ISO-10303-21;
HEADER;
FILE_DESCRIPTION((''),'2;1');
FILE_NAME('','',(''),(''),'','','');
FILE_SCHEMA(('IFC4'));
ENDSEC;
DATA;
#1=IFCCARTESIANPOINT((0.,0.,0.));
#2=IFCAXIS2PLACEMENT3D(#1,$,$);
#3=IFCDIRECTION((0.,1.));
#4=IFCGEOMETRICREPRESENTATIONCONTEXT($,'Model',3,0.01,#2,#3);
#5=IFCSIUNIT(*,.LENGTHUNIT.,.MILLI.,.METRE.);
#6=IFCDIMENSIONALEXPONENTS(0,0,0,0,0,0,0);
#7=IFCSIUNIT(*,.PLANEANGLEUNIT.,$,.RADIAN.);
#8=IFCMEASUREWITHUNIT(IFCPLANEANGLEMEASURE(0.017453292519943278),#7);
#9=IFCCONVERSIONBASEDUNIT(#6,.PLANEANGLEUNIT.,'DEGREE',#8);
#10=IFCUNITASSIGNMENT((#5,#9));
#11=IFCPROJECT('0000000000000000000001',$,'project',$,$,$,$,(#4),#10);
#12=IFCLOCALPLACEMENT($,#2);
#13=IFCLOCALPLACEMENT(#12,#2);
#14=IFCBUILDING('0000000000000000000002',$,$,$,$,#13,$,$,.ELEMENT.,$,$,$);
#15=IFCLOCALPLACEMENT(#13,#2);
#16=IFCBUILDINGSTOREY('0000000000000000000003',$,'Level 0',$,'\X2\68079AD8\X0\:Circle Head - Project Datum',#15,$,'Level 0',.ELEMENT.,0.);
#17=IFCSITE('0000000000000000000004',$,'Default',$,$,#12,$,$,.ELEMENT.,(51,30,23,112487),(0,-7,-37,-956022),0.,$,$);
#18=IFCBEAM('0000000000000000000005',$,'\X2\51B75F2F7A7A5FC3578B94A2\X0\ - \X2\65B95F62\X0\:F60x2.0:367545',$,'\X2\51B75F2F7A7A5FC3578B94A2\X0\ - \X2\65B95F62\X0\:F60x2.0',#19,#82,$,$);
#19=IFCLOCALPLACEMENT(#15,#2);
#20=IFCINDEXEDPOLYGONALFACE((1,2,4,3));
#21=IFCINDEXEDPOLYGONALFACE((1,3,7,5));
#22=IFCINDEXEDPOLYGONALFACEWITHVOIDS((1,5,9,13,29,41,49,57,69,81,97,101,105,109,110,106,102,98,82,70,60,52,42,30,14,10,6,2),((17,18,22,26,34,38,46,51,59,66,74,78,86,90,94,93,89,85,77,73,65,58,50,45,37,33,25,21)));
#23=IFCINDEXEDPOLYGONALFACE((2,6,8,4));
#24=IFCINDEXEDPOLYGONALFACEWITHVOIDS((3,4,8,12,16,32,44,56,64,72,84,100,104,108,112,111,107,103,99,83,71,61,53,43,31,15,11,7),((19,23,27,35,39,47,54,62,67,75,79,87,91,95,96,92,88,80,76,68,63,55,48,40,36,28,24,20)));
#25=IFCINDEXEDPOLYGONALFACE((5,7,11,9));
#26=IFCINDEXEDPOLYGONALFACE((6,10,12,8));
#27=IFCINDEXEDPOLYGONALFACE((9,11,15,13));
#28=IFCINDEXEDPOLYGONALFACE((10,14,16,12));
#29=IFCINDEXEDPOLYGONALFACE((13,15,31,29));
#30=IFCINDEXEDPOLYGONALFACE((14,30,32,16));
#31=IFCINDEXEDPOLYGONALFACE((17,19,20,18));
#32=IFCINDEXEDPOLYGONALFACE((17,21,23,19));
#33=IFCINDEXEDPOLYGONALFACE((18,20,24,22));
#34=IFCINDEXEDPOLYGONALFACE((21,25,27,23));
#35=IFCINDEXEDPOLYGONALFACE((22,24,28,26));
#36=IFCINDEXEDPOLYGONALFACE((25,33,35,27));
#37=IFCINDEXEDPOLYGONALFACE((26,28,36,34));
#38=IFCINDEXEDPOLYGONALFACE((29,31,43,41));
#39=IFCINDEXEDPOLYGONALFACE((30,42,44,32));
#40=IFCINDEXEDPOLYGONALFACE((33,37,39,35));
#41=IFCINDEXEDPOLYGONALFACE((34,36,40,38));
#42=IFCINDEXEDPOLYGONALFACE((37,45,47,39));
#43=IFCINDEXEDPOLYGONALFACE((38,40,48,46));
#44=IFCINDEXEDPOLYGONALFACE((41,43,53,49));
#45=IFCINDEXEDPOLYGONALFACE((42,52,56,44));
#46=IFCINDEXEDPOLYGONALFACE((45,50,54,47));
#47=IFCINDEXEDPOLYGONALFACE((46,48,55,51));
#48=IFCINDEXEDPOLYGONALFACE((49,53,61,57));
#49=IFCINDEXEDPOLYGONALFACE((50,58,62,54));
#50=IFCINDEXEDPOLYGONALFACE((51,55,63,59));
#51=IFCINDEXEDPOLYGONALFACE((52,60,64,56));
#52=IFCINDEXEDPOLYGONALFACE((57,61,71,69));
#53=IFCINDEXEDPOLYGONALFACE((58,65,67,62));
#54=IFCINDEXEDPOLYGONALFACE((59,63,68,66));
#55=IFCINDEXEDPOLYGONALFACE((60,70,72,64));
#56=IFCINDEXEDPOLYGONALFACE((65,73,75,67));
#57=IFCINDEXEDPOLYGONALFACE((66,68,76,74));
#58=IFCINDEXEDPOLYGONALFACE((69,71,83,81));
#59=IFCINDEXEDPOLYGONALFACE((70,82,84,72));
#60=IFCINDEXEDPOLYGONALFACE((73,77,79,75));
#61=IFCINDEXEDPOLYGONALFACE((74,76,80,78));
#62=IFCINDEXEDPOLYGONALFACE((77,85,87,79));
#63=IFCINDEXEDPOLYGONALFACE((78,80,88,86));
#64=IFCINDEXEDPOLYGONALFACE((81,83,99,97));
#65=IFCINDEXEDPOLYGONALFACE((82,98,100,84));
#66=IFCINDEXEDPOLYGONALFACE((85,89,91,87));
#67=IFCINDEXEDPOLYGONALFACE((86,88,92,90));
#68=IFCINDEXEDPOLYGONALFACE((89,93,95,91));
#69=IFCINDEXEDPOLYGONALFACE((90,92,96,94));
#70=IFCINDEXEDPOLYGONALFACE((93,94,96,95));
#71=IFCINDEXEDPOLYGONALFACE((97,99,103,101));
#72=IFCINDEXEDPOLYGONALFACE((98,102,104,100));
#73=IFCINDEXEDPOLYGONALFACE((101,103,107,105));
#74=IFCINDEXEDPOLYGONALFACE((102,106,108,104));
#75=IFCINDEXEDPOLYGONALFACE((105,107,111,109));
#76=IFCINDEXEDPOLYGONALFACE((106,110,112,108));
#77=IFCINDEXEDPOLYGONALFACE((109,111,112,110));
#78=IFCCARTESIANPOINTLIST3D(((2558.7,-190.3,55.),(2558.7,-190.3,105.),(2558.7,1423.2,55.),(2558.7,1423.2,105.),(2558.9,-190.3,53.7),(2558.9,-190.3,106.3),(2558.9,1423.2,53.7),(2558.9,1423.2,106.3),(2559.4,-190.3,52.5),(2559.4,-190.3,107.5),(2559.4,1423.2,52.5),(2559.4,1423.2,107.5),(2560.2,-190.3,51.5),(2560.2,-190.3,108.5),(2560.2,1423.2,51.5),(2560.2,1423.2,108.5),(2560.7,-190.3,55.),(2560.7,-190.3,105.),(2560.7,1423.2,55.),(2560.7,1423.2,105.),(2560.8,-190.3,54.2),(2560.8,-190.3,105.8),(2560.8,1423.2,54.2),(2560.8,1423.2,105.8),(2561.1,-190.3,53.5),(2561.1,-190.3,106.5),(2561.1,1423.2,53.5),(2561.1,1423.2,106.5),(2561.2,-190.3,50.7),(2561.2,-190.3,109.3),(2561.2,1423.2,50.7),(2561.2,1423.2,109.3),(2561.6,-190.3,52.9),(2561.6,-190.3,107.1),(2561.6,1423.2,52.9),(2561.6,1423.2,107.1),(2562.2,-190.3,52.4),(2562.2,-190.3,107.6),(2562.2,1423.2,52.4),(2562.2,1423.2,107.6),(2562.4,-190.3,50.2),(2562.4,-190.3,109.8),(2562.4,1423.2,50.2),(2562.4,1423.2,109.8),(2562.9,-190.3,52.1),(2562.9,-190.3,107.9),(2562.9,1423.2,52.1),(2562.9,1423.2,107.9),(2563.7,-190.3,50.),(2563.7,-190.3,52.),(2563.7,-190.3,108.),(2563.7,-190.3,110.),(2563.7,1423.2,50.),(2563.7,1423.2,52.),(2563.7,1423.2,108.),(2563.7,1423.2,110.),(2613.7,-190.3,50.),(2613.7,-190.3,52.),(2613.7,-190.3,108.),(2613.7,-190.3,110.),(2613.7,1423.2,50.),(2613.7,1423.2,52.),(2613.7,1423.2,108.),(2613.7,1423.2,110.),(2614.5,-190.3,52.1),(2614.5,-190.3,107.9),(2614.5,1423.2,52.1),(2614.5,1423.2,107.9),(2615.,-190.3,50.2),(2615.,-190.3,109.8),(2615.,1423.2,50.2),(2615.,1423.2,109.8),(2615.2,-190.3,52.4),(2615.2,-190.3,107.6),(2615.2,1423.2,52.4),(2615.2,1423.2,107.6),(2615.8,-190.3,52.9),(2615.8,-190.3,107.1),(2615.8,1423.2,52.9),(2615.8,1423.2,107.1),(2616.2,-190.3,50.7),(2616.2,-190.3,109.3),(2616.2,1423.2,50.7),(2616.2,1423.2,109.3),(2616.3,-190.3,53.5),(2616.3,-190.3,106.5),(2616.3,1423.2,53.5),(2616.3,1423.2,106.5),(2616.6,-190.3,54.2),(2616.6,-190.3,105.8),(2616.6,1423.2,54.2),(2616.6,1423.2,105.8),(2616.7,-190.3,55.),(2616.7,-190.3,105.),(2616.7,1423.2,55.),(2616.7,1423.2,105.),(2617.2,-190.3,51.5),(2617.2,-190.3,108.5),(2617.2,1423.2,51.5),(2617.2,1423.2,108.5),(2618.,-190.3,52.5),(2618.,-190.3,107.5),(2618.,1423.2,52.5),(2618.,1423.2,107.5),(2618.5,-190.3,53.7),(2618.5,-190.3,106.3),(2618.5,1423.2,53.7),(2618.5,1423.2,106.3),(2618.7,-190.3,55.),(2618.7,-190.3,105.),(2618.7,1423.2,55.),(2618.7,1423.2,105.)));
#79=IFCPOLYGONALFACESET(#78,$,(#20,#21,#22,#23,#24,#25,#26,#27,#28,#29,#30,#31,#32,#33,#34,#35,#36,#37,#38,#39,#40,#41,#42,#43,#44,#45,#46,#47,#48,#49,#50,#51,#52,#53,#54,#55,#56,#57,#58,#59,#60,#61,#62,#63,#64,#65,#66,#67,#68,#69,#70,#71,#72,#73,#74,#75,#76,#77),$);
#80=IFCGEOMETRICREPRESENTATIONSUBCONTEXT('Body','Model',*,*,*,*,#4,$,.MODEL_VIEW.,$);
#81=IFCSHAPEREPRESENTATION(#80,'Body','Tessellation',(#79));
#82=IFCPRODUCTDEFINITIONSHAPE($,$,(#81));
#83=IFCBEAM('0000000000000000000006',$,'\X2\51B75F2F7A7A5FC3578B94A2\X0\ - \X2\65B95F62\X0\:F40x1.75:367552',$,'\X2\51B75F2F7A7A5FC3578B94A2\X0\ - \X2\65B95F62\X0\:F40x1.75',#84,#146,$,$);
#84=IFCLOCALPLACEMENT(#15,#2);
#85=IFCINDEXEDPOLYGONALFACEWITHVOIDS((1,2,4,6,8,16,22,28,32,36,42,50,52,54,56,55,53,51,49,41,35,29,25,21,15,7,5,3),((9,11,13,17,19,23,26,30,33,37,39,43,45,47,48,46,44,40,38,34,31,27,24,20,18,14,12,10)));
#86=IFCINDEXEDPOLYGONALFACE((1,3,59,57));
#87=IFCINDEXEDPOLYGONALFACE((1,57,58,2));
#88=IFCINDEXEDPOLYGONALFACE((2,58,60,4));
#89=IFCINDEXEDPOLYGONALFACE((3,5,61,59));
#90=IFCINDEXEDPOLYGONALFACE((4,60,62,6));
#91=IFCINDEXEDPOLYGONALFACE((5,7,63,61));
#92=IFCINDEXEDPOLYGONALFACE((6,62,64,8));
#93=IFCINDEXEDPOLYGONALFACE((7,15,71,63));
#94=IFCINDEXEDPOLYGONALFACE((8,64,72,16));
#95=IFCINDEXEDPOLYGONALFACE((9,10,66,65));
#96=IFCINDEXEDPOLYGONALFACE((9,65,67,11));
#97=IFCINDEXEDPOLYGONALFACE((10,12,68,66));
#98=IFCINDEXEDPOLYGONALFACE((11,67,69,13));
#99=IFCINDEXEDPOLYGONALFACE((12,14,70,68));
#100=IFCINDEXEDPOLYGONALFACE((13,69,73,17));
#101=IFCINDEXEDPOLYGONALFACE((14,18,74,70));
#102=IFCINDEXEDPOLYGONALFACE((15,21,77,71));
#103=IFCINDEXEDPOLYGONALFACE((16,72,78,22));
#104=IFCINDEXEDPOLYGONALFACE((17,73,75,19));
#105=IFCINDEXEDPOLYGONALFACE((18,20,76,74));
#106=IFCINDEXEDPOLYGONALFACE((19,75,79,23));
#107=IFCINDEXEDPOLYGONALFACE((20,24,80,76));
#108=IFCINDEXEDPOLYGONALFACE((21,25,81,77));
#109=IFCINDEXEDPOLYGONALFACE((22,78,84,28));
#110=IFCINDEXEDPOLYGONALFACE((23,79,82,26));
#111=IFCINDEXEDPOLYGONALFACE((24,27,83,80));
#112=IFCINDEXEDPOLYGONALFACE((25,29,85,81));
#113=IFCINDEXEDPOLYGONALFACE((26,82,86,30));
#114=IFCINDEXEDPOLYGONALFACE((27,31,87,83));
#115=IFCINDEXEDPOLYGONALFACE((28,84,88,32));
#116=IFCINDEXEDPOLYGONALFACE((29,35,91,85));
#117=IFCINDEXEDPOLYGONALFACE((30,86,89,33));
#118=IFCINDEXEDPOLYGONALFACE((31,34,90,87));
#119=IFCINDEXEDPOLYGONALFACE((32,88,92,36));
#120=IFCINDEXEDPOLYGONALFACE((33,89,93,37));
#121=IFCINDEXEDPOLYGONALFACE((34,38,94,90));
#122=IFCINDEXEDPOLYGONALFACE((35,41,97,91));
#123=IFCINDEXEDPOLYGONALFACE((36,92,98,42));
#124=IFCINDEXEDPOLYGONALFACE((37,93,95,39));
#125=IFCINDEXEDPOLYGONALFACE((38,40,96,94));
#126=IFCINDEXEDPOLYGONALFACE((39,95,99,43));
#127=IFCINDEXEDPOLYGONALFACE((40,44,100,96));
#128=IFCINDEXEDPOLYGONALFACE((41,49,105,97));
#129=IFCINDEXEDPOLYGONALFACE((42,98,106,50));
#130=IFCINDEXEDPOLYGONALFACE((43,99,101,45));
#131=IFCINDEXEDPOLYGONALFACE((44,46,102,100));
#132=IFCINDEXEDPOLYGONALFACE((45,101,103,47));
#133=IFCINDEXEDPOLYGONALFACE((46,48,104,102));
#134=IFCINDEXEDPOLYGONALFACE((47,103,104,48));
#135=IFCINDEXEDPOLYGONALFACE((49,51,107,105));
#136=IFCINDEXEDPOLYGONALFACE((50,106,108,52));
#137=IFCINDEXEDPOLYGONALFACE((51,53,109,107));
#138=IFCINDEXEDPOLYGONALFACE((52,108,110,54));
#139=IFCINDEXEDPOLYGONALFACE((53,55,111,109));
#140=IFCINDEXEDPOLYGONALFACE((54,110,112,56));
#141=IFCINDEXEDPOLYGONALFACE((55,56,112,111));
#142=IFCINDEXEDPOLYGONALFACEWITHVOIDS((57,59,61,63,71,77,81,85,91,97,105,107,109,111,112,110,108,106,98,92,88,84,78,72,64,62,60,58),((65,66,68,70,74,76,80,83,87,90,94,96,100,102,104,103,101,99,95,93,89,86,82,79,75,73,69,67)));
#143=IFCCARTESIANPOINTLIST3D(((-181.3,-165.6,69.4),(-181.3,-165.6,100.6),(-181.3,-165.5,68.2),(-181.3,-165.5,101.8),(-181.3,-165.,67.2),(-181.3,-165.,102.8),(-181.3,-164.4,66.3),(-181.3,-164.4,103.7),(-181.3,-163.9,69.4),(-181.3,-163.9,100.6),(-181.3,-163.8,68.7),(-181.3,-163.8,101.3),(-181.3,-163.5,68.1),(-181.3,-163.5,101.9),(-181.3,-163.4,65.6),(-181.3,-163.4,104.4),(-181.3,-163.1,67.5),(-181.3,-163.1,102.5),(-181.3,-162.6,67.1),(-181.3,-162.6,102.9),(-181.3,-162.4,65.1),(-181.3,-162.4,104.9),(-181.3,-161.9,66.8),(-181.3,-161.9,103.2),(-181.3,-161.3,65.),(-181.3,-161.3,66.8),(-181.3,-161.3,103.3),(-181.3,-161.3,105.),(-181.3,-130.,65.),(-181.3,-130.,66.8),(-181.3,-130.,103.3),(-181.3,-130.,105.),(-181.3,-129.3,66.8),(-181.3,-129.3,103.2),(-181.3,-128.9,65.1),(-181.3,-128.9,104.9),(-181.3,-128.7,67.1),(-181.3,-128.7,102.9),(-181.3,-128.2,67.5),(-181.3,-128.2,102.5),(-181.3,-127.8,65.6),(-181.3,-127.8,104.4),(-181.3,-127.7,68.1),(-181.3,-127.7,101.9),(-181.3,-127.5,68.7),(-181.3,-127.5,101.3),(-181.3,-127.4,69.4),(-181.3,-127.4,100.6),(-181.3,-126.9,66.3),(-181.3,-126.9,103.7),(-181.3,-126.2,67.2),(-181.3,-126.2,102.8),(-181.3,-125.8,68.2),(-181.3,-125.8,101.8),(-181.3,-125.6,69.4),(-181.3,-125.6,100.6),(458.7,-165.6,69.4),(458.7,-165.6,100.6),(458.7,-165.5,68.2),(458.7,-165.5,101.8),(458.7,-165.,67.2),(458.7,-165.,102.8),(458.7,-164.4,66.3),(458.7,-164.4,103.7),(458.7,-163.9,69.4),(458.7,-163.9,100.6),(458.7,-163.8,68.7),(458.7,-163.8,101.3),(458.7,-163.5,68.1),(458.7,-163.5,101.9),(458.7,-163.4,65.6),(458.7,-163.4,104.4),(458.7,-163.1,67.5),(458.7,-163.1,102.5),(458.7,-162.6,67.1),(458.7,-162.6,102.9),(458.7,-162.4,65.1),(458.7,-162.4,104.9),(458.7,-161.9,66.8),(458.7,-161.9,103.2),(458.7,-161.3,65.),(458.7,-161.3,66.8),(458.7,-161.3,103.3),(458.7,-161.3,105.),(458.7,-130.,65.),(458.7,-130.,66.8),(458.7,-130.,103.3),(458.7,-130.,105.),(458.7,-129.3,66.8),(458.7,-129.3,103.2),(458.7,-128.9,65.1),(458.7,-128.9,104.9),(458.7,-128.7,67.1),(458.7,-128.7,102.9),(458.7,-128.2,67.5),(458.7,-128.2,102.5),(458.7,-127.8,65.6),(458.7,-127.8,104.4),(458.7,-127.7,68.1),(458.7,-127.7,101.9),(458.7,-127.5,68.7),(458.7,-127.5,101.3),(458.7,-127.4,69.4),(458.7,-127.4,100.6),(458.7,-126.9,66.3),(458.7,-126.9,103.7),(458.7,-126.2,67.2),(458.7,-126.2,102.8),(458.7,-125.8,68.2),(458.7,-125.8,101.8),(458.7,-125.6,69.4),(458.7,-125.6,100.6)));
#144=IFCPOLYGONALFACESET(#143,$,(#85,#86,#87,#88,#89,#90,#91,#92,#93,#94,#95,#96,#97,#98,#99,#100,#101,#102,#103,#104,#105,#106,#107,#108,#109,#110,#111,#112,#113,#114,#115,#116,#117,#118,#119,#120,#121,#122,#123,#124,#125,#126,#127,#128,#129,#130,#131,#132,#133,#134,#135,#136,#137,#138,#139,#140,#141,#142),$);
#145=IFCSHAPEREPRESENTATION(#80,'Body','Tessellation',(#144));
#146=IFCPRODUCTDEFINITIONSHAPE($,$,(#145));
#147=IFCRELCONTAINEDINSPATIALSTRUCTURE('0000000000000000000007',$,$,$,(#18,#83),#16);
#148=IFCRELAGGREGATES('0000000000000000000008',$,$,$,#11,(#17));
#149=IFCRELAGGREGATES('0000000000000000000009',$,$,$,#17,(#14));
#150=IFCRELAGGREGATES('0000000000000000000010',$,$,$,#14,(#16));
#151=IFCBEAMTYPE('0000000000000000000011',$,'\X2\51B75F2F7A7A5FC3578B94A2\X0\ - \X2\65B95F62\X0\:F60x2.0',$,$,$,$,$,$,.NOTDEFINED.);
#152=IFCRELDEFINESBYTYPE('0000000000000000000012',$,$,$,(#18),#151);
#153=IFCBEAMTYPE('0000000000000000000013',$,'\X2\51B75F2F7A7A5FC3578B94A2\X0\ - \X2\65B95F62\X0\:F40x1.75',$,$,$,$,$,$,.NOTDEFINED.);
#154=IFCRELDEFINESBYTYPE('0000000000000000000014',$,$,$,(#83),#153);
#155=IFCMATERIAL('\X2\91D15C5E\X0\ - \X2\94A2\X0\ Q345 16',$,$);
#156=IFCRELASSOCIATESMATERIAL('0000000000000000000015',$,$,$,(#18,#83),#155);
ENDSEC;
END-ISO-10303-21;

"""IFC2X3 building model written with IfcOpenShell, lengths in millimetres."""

from ifc_helpers import new_model, entity, si_unit, converted_unit, direction, frame, frame_2d, origin, place, context, subcontext, project, spatial, polyline, circle_curve, parameter, trimmed, segment, composite_curve, outline, extrude, material, type_object, element, save


model = new_model("IFC2X3")

# Units and contexts
model_context = context("Model", 3, precision=0.01, world=origin(), true_north=direction((0.0, 1.0)))
body_context = subcontext(model_context, "Body", "Model", "MODEL_VIEW")
ifc_project = project(units=[si_unit("LENGTHUNIT", "METRE", prefix="MILLI"), converted_unit("PLANEANGLEUNIT", "DEGREE", entity("IfcPlaneAngleMeasure", 0.017453292519943278), si_unit("PLANEANGLEUNIT", "RADIAN"), dimensions=[0, 0, 0, 0, 0, 0, 0])], contexts=[model_context])

# Site, building, storey
site_placement = place(None, origin())
site = spatial("IfcSite", under=ifc_project, at=site_placement, Name="Default", CompositionType="ELEMENT", RefLatitude=(51, 30, 23, 112487), RefLongitude=(0, -7, -37, -956022), RefElevation=0.0)
building_placement = place(site_placement, origin())
building = spatial("IfcBuilding", under=site, at=building_placement, CompositionType="ELEMENT")
storey_placement = place(building_placement, origin())
storey = spatial("IfcBuildingStorey", under=building, at=storey_placement, Name="Level 0", ObjectType="标高:Circle Head - Project Datum", LongName="Level 0", CompositionType="ELEMENT", Elevation=0.0)

# Beams
ifc_material_1 = material(Name="金属 - 钢 Q345 16")
beam_type_1 = type_object("IfcBeamType", Name="冷弯空心型钢 - 方形:F60x2.0", PredefinedType="NOTDEFINED")
beam_1_placement = place(storey_placement, frame((2588.7, 1388.1, 110.0), z_axis=(0.0, 0.0, 1.0), x_axis=(0.0, -1.0, 0.0)))
element("IfcBeam", 1, at=beam_1_placement, inside=storey, type_object=beam_type_1, material=ifc_material_1, Name="冷弯空心型钢 - 方形:F60x2.0:367545", ObjectType="冷弯空心型钢 - 方形:F60x2.0", context=body_context, shape_type="SweptSolid", body=[
    extrude(outline(composite_curve([segment(trimmed(circle_curve(frame_2d((-25.0, 25.0), x_axis=(1.0, 0.0)), 5.0), [parameter(90.0)], [parameter(180.0)], True, "PARAMETER"), True, "CONTINUOUS"), segment(polyline([(-30.0, 25.0), (-30.0, -25.0)]), True, "CONTINUOUS"), segment(trimmed(circle_curve(frame_2d((-25.0, -25.0), x_axis=(1.0, 0.0)), 5.0), [parameter(180.0)], [parameter(270.0)], True, "PARAMETER"), True, "CONTINUOUS"), segment(polyline([(-25.0, -30.0), (25.0, -30.0)]), True, "CONTINUOUS"), segment(trimmed(circle_curve(frame_2d((25.0, -25.0), x_axis=(1.0, 0.0)), 5.0), [parameter(270.0)], [parameter(0.0)], True, "PARAMETER"), True, "CONTINUOUS"), segment(polyline([(30.0, -25.0), (30.0, 25.0)]), True, "CONTINUOUS"), segment(trimmed(circle_curve(frame_2d((25.0, 25.0), x_axis=(1.0, 0.0)), 5.0), [parameter(0.0)], [parameter(90.0)], True, "PARAMETER"), True, "CONTINUOUS"), segment(polyline([(25.0, 30.0), (-25.0, 30.0)]), True, "CONTINUOUS")], self_intersect=False), holes=[composite_curve([segment(polyline([(-25.0, 28.0), (25.0, 28.0)]), True, "CONTINUOUS"), segment(trimmed(circle_curve(frame_2d((25.0, 25.0), x_axis=(1.0, 0.0)), 3.0), [parameter(0.0)], [parameter(90.0)], True, "PARAMETER"), False, "CONTINUOUS"), segment(polyline([(28.0, 25.0), (28.0, -25.0)]), True, "CONTINUOUS"), segment(trimmed(circle_curve(frame_2d((25.0, -25.0), x_axis=(1.0, 0.0)), 3.0), [parameter(270.0)], [parameter(360.0)], True, "PARAMETER"), False, "CONTINUOUS"), segment(polyline([(25.0, -28.0), (-25.0, -28.0)]), True, "CONTINUOUS"), segment(trimmed(circle_curve(frame_2d((-25.0, -25.0), x_axis=(1.0, 0.0)), 3.0), [parameter(180.0)], [parameter(270.0)], True, "PARAMETER"), False, "CONTINUOUS"), segment(polyline([(-28.0, -25.0), (-28.0, 25.0)]), True, "CONTINUOUS"), segment(trimmed(circle_curve(frame_2d((-25.0, 25.0), x_axis=(1.0, 0.0)), 3.0), [parameter(90.0)], [parameter(180.0)], True, "PARAMETER"), False, "CONTINUOUS")], self_intersect=False)]), frame((-35.1, 0.0, -30.0), z_axis=(1.0, 0.0, 0.0), x_axis=(0.0, 1.0, 0.0)), (0.0, 0.0, 1.0), 1613.5),
])
beam_type_2 = type_object("IfcBeamType", Name="冷弯空心型钢 - 方形:F40x1.75", PredefinedType="NOTDEFINED")
beam_2_placement = place(storey_placement, frame((-146.3, -145.6, 105.0)))
element("IfcBeam", 2, at=beam_2_placement, inside=storey, type_object=beam_type_2, material=ifc_material_1, Name="冷弯空心型钢 - 方形:F40x1.75:367552", ObjectType="冷弯空心型钢 - 方形:F40x1.75", context=body_context, shape_type="SweptSolid", body=[
    extrude(outline(composite_curve([segment(trimmed(circle_curve(frame_2d((-15.6, 15.6), x_axis=(1.0, 0.0)), 4.4), [parameter(90.0)], [parameter(180.0)], True, "PARAMETER"), True, "CONTINUOUS"), segment(polyline([(-20.0, 15.6), (-20.0, -15.6)]), True, "CONTINUOUS"), segment(trimmed(circle_curve(frame_2d((-15.6, -15.6), x_axis=(1.0, 0.0)), 4.4), [parameter(180.0)], [parameter(270.0)], True, "PARAMETER"), True, "CONTINUOUS"), segment(polyline([(-15.6, -20.0), (15.6, -20.0)]), True, "CONTINUOUS"), segment(trimmed(circle_curve(frame_2d((15.6, -15.6), x_axis=(1.0, 0.0)), 4.4), [parameter(270.0)], [parameter(0.0)], True, "PARAMETER"), True, "CONTINUOUS"), segment(polyline([(20.0, -15.6), (20.0, 15.6)]), True, "CONTINUOUS"), segment(trimmed(circle_curve(frame_2d((15.6, 15.6), x_axis=(1.0, 0.0)), 4.4), [parameter(0.0)], [parameter(90.0)], True, "PARAMETER"), True, "CONTINUOUS"), segment(polyline([(15.6, 20.0), (-15.6, 20.0)]), True, "CONTINUOUS")], self_intersect=False), holes=[composite_curve([segment(polyline([(-15.6, 18.3), (15.6, 18.3)]), True, "CONTINUOUS"), segment(trimmed(circle_curve(frame_2d((15.6, 15.6), x_axis=(1.0, 0.0)), 2.6), [parameter(0.0)], [parameter(90.0)], True, "PARAMETER"), False, "CONTINUOUS"), segment(polyline([(18.2, 15.6), (18.2, -15.6)]), True, "CONTINUOUS"), segment(trimmed(circle_curve(frame_2d((15.6, -15.6), x_axis=(1.0, 0.0)), 2.6), [parameter(270.0)], [parameter(360.0)], True, "PARAMETER"), False, "CONTINUOUS"), segment(polyline([(15.6, -18.2), (-15.6, -18.2)]), True, "CONTINUOUS"), segment(trimmed(circle_curve(frame_2d((-15.6, -15.6), x_axis=(1.0, 0.0)), 2.6), [parameter(180.0)], [parameter(270.0)], True, "PARAMETER"), False, "CONTINUOUS"), segment(polyline([(-18.3, -15.6), (-18.3, 15.6)]), True, "CONTINUOUS"), segment(trimmed(circle_curve(frame_2d((-15.6, 15.6), x_axis=(1.0, 0.0)), 2.6), [parameter(90.0)], [parameter(180.0)], True, "PARAMETER"), False, "CONTINUOUS")], self_intersect=False)]), frame((-35.0, 0.0, -20.0), z_axis=(1.0, 0.0, 0.0), x_axis=(0.0, 1.0, 0.0)), (0.0, 0.0, 1.0), 640.0),
])

save(model, "model.ifc")
